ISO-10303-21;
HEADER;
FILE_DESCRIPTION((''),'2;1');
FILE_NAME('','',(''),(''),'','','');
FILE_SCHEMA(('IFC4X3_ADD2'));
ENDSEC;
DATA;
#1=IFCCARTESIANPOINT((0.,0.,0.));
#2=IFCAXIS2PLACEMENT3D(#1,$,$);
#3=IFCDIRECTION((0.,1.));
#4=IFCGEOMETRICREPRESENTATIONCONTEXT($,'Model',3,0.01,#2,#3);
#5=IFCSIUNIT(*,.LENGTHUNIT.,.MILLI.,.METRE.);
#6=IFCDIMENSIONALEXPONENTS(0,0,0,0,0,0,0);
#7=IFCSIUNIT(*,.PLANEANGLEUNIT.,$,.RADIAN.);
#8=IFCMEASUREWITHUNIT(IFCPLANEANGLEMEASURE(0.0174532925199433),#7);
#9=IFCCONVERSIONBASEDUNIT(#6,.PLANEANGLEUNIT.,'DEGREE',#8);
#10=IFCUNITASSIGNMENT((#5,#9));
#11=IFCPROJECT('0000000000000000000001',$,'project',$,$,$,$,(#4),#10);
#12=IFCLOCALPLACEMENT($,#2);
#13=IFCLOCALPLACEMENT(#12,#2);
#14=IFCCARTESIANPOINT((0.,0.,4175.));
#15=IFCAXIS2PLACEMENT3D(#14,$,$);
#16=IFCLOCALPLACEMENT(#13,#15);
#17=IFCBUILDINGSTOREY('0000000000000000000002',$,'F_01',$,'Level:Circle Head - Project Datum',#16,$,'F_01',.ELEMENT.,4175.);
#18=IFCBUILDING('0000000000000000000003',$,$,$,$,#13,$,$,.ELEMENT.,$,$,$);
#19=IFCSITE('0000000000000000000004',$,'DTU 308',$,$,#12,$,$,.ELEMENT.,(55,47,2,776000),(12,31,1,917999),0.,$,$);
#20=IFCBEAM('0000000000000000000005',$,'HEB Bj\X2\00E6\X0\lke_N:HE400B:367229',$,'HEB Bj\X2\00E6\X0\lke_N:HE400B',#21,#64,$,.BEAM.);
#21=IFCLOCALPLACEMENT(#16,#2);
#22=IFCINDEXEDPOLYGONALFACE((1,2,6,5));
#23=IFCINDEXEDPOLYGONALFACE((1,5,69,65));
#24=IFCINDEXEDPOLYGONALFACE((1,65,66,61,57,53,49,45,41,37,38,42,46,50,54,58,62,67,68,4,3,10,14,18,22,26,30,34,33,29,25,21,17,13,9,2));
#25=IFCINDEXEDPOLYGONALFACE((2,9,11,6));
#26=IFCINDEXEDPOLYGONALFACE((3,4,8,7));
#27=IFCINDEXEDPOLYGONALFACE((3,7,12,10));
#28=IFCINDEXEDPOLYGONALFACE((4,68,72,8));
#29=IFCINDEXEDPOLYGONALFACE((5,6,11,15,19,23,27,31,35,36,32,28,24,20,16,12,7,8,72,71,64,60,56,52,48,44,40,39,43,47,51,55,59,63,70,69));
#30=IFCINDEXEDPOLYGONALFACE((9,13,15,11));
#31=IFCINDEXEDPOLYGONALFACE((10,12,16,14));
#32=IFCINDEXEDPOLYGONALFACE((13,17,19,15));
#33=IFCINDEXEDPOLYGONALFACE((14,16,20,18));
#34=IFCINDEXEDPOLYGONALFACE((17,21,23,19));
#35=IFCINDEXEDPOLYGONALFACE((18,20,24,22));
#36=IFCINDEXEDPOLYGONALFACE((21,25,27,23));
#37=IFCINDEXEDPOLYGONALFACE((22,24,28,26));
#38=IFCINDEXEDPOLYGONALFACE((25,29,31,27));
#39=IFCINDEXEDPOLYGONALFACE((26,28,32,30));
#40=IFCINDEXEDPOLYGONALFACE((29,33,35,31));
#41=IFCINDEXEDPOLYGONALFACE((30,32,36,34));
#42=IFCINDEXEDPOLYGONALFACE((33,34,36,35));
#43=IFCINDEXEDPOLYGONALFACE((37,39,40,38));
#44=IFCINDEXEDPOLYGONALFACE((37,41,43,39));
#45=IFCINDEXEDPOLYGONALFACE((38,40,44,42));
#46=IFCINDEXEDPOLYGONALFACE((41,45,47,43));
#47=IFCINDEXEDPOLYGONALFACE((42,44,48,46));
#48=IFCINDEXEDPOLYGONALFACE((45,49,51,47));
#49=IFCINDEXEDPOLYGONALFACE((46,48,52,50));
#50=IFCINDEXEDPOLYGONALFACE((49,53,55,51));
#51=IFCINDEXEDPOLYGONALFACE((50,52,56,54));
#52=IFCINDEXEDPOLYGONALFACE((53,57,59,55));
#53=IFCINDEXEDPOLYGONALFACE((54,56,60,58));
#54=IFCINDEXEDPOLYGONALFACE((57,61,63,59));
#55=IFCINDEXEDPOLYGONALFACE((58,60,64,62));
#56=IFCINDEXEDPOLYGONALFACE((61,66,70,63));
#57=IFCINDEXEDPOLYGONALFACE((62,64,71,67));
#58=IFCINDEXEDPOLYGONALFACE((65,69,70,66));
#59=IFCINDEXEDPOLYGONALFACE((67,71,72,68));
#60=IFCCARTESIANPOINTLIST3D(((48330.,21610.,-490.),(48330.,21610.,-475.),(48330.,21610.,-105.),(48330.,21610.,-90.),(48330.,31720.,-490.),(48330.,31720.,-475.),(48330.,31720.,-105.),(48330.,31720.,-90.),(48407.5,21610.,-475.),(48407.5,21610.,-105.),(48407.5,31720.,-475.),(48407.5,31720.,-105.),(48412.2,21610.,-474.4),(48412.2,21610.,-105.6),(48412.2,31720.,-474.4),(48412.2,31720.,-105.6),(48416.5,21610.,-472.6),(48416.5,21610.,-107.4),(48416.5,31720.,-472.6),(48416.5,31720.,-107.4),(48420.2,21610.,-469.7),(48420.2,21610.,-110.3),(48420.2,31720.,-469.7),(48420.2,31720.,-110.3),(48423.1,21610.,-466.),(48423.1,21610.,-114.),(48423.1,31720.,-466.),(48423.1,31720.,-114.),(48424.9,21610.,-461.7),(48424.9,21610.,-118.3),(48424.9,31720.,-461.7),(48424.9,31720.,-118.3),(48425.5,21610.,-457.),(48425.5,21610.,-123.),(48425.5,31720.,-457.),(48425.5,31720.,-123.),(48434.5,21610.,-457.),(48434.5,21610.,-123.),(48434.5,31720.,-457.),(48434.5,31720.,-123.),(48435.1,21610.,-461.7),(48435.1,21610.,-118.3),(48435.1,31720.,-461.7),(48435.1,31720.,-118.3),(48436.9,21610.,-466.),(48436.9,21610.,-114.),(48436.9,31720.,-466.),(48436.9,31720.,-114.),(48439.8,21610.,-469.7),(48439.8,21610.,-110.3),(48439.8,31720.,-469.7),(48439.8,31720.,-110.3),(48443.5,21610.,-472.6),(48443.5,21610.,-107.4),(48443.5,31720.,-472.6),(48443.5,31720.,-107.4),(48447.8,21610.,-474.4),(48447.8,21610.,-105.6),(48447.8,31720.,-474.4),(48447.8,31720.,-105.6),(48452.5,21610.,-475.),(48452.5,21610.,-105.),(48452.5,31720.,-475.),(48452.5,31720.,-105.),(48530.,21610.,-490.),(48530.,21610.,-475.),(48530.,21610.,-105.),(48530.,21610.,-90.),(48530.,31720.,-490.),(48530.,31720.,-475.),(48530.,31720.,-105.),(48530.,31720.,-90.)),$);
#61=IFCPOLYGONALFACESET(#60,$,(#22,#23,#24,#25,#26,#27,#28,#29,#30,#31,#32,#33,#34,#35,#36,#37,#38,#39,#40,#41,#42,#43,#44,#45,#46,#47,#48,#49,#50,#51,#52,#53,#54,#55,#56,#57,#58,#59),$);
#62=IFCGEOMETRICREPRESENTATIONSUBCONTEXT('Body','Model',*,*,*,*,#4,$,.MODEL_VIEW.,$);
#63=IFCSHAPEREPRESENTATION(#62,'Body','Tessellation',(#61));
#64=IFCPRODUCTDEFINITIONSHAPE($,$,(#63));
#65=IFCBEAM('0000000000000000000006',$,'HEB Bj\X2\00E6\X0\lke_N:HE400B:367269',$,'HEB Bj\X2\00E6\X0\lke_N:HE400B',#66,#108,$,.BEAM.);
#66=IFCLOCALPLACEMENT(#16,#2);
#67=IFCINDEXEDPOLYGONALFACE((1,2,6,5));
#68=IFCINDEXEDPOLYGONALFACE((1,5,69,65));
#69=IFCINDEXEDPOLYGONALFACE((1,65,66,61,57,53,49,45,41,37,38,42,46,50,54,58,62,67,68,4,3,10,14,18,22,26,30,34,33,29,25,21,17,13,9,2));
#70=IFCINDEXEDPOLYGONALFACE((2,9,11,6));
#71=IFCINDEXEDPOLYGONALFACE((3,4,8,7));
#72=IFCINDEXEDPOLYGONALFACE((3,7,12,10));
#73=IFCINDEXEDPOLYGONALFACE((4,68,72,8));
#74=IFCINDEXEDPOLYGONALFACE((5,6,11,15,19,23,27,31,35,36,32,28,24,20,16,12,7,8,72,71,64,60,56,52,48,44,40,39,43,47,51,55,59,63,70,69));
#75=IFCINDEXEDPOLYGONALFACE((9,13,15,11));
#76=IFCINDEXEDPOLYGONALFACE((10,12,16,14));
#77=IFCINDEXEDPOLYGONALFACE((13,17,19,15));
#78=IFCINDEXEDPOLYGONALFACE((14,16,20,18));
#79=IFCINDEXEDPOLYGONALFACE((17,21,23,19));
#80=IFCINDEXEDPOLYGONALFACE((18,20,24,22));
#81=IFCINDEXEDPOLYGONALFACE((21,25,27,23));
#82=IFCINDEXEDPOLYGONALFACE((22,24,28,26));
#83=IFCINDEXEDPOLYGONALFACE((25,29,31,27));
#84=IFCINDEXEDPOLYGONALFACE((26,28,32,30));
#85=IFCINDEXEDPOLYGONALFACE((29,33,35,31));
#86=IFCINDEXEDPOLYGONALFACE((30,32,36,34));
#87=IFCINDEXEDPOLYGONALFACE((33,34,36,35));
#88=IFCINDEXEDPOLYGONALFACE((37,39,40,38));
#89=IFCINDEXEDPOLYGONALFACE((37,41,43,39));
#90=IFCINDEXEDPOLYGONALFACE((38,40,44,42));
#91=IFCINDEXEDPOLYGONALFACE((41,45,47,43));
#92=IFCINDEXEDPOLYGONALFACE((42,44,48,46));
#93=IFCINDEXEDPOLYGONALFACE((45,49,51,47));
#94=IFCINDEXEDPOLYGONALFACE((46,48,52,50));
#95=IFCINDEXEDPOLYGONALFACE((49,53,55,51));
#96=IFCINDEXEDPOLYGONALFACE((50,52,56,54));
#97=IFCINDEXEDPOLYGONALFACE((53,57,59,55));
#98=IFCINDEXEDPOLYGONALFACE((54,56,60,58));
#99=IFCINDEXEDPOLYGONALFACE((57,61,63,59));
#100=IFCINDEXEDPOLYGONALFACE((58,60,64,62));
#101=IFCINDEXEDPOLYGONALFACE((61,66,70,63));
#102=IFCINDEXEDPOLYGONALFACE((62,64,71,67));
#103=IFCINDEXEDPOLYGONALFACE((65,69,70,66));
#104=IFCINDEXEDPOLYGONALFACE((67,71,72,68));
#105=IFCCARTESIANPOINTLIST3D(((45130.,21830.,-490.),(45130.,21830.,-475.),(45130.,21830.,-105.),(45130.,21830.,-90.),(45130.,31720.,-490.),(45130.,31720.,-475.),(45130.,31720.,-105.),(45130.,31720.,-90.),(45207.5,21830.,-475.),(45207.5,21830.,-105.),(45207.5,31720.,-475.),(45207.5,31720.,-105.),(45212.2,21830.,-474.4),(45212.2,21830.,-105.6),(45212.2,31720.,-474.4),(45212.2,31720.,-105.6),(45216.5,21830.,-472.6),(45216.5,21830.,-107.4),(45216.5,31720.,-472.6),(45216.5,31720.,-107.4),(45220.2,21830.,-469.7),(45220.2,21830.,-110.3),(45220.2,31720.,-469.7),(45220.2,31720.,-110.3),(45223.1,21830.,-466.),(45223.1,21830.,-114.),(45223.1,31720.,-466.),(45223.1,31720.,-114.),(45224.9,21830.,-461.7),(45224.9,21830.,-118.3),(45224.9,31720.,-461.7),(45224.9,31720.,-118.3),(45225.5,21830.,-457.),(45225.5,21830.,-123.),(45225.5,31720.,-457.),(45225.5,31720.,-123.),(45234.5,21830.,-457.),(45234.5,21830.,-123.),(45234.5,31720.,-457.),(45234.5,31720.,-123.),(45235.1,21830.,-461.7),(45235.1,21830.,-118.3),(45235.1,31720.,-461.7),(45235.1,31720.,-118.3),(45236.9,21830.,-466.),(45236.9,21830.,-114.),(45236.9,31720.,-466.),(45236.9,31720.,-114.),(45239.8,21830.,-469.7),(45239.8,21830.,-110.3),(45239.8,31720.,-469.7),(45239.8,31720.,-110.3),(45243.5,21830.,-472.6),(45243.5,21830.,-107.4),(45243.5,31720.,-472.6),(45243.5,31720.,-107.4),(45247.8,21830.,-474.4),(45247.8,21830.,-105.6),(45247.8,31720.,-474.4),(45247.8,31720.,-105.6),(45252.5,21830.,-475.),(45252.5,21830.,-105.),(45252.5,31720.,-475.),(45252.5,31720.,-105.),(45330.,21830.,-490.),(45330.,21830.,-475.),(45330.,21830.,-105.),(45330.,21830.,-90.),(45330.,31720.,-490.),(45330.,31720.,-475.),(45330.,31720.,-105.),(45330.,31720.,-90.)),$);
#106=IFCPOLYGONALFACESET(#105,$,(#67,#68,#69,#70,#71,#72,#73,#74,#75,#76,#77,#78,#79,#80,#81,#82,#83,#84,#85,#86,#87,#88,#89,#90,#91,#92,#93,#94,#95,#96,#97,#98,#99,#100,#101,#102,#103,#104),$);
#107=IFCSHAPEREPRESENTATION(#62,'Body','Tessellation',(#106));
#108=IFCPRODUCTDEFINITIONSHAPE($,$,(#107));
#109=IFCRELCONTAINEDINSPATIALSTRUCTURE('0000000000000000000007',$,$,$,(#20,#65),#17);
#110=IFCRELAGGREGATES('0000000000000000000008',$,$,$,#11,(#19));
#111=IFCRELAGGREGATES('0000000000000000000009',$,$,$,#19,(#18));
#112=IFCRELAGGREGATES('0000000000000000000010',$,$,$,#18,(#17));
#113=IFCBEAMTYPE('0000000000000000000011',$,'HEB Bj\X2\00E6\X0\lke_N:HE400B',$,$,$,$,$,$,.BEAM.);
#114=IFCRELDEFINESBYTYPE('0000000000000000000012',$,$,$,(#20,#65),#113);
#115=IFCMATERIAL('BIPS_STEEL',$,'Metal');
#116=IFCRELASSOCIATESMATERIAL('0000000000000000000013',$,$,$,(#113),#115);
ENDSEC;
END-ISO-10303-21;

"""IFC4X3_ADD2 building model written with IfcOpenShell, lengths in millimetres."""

from ifc_helpers import new_model, entity, si_unit, converted_unit, direction, frame, frame_2d, origin, place, context, subcontext, project, spatial, polyline, circle_curve, parameter, trimmed, segment, composite_curve, outline, extrude, source, transform, mapped, material, material_profile, profile_set, type_object, element, save


model = new_model("IFC4X3_ADD2")

# Units and contexts
model_context = context("Model", 3, precision=0.01, world=origin(), true_north=direction((0.0, 1.0)))
body_context = subcontext(model_context, "Body", "Model", "MODEL_VIEW")
ifc_project = project(units=[si_unit("LENGTHUNIT", "METRE", prefix="MILLI"), converted_unit("PLANEANGLEUNIT", "DEGREE", entity("IfcPlaneAngleMeasure", 0.0174532925199433), si_unit("PLANEANGLEUNIT", "RADIAN"), dimensions=[0, 0, 0, 0, 0, 0, 0])], contexts=[model_context])

# Site, building, storey
site_placement = place(None, origin())
site = spatial("IfcSite", under=ifc_project, at=site_placement, Name="DTU 308", CompositionType="ELEMENT", RefLatitude=(55, 47, 2, 776000), RefLongitude=(12, 31, 1, 917999), RefElevation=0.0)
building_placement = place(site_placement, origin())
building = spatial("IfcBuilding", under=site, at=building_placement, CompositionType="ELEMENT")
storey_placement = place(building_placement, frame((0.0, 0.0, 4175.0)))
storey = spatial("IfcBuildingStorey", under=building, at=storey_placement, Name="F_01", ObjectType="Level:Circle Head - Project Datum", LongName="F_01", CompositionType="ELEMENT", Elevation=4175.0)

# Shared definitions
ifc_material_1 = material(Name="BIPS_STEEL", Category="Metal")

# Beams
ifc_material_profile_1 = material_profile(ifc_material_1, outline(composite_curve([segment(polyline([(-100.0, -185.0), (-100.0, -200.0)]), True, "CONTINUOUS"), segment(polyline([(-100.0, -200.0), (100.0, -200.0)]), True, "CONTINUOUS"), segment(polyline([(100.0, -200.0), (100.0, -185.0)]), True, "CONTINUOUS"), segment(polyline([(100.0, -185.0), (22.5, -185.0)]), True, "CONTINUOUS"), segment(trimmed(circle_curve(frame_2d((22.5, -167.0), x_axis=(1.0, 0.0)), 18.0), [parameter(180.0)], [parameter(270.0)], True, "PARAMETER"), False, "CONTINUOUS"), segment(polyline([(4.5, -167.0), (4.5, 167.0)]), True, "CONTINUOUS"), segment(trimmed(circle_curve(frame_2d((22.5, 167.0), x_axis=(1.0, 0.0)), 18.0), [parameter(90.0)], [parameter(180.0)], True, "PARAMETER"), False, "CONTINUOUS"), segment(polyline([(22.5, 185.0), (100.0, 185.0)]), True, "CONTINUOUS"), segment(polyline([(100.0, 185.0), (100.0, 200.0)]), True, "CONTINUOUS"), segment(polyline([(100.0, 200.0), (-100.0, 200.0)]), True, "CONTINUOUS"), segment(polyline([(-100.0, 200.0), (-100.0, 185.0)]), True, "CONTINUOUS"), segment(polyline([(-100.0, 185.0), (-22.5, 185.0)]), True, "CONTINUOUS"), segment(trimmed(circle_curve(frame_2d((-22.5, 167.0), x_axis=(1.0, 0.0)), 18.0), [parameter(360.0)], [parameter(90.0)], True, "PARAMETER"), False, "CONTINUOUS"), segment(polyline([(-4.5, 167.0), (-4.5, -167.0)]), True, "CONTINUOUS"), segment(trimmed(circle_curve(frame_2d((-22.5, -167.0), x_axis=(1.0, 0.0)), 18.0), [parameter(270.0)], [parameter(360.0)], True, "PARAMETER"), False, "CONTINUOUS"), segment(polyline([(-22.5, -185.0), (-100.0, -185.0)]), True, "CONTINUOUS")], self_intersect=False)), Name="HE400B")
ifc_profile_set_1 = profile_set([ifc_material_profile_1], Name="HE400B")
beam_type_1 = type_object("IfcBeamType", Name="HEB Bjælke_N:HE400B", PredefinedType="BEAM", material=ifc_profile_set_1)
shared_shape_1 = source(origin(), body_context, "Body", "SweptSolid", [
    extrude(outline(composite_curve([segment(polyline([(-100.0, -185.0), (-100.0, -200.0)]), True, "CONTINUOUS"), segment(polyline([(-100.0, -200.0), (100.0, -200.0)]), True, "CONTINUOUS"), segment(polyline([(100.0, -200.0), (100.0, -185.0)]), True, "CONTINUOUS"), segment(polyline([(100.0, -185.0), (22.5, -185.0)]), True, "CONTINUOUS"), segment(trimmed(circle_curve(frame_2d((22.5, -167.0), x_axis=(1.0, 0.0)), 18.0), [parameter(180.0)], [parameter(270.0)], True, "PARAMETER"), False, "CONTINUOUS"), segment(polyline([(4.5, -167.0), (4.5, 167.0)]), True, "CONTINUOUS"), segment(trimmed(circle_curve(frame_2d((22.5, 167.0), x_axis=(1.0, 0.0)), 18.0), [parameter(90.0)], [parameter(180.0)], True, "PARAMETER"), False, "CONTINUOUS"), segment(polyline([(22.5, 185.0), (100.0, 185.0)]), True, "CONTINUOUS"), segment(polyline([(100.0, 185.0), (100.0, 200.0)]), True, "CONTINUOUS"), segment(polyline([(100.0, 200.0), (-100.0, 200.0)]), True, "CONTINUOUS"), segment(polyline([(-100.0, 200.0), (-100.0, 185.0)]), True, "CONTINUOUS"), segment(polyline([(-100.0, 185.0), (-22.5, 185.0)]), True, "CONTINUOUS"), segment(trimmed(circle_curve(frame_2d((-22.5, 167.0), x_axis=(1.0, 0.0)), 18.0), [parameter(360.0)], [parameter(90.0)], True, "PARAMETER"), False, "CONTINUOUS"), segment(polyline([(-4.5, 167.0), (-4.5, -167.0)]), True, "CONTINUOUS"), segment(trimmed(circle_curve(frame_2d((-22.5, -167.0), x_axis=(1.0, 0.0)), 18.0), [parameter(270.0)], [parameter(360.0)], True, "PARAMETER"), False, "CONTINUOUS"), segment(polyline([(-22.5, -185.0), (-100.0, -185.0)]), True, "CONTINUOUS")], self_intersect=False)), frame((-5065.0, 0.0, 0.0), z_axis=(-1.0, 0.0, 0.0), x_axis=(0.0, -1.0, 0.0)), (0.0, 0.0, -1.0), 10110.0),
])
beam_1_placement = place(storey_placement, frame((48430.0, 26655.0, -290.0), z_axis=(0.0, 0.0, 1.0), x_axis=(0.0, -1.0, 0.0)))
element("IfcBeam", 1, at=beam_1_placement, inside=storey, type_object=beam_type_1, Name="HEB Bjælke_N:HE400B:367229", ObjectType="HEB Bjælke_N:HE400B", PredefinedType="BEAM", context=body_context, shape_type="MappedRepresentation", body=[
    mapped(shared_shape_1, transform((0.0, 0.0, 0.0), scale=1.0)),
])
shared_shape_2 = source(origin(), body_context, "Body", "SweptSolid", [
    extrude(outline(composite_curve([segment(polyline([(-100.0, -185.0), (-100.0, -200.0)]), True, "CONTINUOUS"), segment(polyline([(-100.0, -200.0), (100.0, -200.0)]), True, "CONTINUOUS"), segment(polyline([(100.0, -200.0), (100.0, -185.0)]), True, "CONTINUOUS"), segment(polyline([(100.0, -185.0), (22.5, -185.0)]), True, "CONTINUOUS"), segment(trimmed(circle_curve(frame_2d((22.5, -167.0), x_axis=(1.0, 0.0)), 18.0), [parameter(180.0)], [parameter(270.0)], True, "PARAMETER"), False, "CONTINUOUS"), segment(polyline([(4.5, -167.0), (4.5, 167.0)]), True, "CONTINUOUS"), segment(trimmed(circle_curve(frame_2d((22.5, 167.0), x_axis=(1.0, 0.0)), 18.0), [parameter(90.0)], [parameter(180.0)], True, "PARAMETER"), False, "CONTINUOUS"), segment(polyline([(22.5, 185.0), (100.0, 185.0)]), True, "CONTINUOUS"), segment(polyline([(100.0, 185.0), (100.0, 200.0)]), True, "CONTINUOUS"), segment(polyline([(100.0, 200.0), (-100.0, 200.0)]), True, "CONTINUOUS"), segment(polyline([(-100.0, 200.0), (-100.0, 185.0)]), True, "CONTINUOUS"), segment(polyline([(-100.0, 185.0), (-22.5, 185.0)]), True, "CONTINUOUS"), segment(trimmed(circle_curve(frame_2d((-22.5, 167.0), x_axis=(1.0, 0.0)), 18.0), [parameter(360.0)], [parameter(90.0)], True, "PARAMETER"), False, "CONTINUOUS"), segment(polyline([(-4.5, 167.0), (-4.5, -167.0)]), True, "CONTINUOUS"), segment(trimmed(circle_curve(frame_2d((-22.5, -167.0), x_axis=(1.0, 0.0)), 18.0), [parameter(270.0)], [parameter(360.0)], True, "PARAMETER"), False, "CONTINUOUS"), segment(polyline([(-22.5, -185.0), (-100.0, -185.0)]), True, "CONTINUOUS")], self_intersect=False)), frame((-4825.0, 0.0, 0.0), z_axis=(-1.0, 0.0, 0.0), x_axis=(0.0, -1.0, 0.0)), (0.0, 0.0, -1.0), 9890.0),
])
beam_2_placement = place(storey_placement, frame((45230.0, 26655.0, -290.0), z_axis=(0.0, 0.0, 1.0), x_axis=(0.0, 1.0, 0.0)))
element("IfcBeam", 2, at=beam_2_placement, inside=storey, type_object=beam_type_1, Name="HEB Bjælke_N:HE400B:367269", ObjectType="HEB Bjælke_N:HE400B", PredefinedType="BEAM", context=body_context, shape_type="MappedRepresentation", body=[
    mapped(shared_shape_2, transform((0.0, 0.0, 0.0), scale=1.0)),
])

save(model, "model.ifc")
